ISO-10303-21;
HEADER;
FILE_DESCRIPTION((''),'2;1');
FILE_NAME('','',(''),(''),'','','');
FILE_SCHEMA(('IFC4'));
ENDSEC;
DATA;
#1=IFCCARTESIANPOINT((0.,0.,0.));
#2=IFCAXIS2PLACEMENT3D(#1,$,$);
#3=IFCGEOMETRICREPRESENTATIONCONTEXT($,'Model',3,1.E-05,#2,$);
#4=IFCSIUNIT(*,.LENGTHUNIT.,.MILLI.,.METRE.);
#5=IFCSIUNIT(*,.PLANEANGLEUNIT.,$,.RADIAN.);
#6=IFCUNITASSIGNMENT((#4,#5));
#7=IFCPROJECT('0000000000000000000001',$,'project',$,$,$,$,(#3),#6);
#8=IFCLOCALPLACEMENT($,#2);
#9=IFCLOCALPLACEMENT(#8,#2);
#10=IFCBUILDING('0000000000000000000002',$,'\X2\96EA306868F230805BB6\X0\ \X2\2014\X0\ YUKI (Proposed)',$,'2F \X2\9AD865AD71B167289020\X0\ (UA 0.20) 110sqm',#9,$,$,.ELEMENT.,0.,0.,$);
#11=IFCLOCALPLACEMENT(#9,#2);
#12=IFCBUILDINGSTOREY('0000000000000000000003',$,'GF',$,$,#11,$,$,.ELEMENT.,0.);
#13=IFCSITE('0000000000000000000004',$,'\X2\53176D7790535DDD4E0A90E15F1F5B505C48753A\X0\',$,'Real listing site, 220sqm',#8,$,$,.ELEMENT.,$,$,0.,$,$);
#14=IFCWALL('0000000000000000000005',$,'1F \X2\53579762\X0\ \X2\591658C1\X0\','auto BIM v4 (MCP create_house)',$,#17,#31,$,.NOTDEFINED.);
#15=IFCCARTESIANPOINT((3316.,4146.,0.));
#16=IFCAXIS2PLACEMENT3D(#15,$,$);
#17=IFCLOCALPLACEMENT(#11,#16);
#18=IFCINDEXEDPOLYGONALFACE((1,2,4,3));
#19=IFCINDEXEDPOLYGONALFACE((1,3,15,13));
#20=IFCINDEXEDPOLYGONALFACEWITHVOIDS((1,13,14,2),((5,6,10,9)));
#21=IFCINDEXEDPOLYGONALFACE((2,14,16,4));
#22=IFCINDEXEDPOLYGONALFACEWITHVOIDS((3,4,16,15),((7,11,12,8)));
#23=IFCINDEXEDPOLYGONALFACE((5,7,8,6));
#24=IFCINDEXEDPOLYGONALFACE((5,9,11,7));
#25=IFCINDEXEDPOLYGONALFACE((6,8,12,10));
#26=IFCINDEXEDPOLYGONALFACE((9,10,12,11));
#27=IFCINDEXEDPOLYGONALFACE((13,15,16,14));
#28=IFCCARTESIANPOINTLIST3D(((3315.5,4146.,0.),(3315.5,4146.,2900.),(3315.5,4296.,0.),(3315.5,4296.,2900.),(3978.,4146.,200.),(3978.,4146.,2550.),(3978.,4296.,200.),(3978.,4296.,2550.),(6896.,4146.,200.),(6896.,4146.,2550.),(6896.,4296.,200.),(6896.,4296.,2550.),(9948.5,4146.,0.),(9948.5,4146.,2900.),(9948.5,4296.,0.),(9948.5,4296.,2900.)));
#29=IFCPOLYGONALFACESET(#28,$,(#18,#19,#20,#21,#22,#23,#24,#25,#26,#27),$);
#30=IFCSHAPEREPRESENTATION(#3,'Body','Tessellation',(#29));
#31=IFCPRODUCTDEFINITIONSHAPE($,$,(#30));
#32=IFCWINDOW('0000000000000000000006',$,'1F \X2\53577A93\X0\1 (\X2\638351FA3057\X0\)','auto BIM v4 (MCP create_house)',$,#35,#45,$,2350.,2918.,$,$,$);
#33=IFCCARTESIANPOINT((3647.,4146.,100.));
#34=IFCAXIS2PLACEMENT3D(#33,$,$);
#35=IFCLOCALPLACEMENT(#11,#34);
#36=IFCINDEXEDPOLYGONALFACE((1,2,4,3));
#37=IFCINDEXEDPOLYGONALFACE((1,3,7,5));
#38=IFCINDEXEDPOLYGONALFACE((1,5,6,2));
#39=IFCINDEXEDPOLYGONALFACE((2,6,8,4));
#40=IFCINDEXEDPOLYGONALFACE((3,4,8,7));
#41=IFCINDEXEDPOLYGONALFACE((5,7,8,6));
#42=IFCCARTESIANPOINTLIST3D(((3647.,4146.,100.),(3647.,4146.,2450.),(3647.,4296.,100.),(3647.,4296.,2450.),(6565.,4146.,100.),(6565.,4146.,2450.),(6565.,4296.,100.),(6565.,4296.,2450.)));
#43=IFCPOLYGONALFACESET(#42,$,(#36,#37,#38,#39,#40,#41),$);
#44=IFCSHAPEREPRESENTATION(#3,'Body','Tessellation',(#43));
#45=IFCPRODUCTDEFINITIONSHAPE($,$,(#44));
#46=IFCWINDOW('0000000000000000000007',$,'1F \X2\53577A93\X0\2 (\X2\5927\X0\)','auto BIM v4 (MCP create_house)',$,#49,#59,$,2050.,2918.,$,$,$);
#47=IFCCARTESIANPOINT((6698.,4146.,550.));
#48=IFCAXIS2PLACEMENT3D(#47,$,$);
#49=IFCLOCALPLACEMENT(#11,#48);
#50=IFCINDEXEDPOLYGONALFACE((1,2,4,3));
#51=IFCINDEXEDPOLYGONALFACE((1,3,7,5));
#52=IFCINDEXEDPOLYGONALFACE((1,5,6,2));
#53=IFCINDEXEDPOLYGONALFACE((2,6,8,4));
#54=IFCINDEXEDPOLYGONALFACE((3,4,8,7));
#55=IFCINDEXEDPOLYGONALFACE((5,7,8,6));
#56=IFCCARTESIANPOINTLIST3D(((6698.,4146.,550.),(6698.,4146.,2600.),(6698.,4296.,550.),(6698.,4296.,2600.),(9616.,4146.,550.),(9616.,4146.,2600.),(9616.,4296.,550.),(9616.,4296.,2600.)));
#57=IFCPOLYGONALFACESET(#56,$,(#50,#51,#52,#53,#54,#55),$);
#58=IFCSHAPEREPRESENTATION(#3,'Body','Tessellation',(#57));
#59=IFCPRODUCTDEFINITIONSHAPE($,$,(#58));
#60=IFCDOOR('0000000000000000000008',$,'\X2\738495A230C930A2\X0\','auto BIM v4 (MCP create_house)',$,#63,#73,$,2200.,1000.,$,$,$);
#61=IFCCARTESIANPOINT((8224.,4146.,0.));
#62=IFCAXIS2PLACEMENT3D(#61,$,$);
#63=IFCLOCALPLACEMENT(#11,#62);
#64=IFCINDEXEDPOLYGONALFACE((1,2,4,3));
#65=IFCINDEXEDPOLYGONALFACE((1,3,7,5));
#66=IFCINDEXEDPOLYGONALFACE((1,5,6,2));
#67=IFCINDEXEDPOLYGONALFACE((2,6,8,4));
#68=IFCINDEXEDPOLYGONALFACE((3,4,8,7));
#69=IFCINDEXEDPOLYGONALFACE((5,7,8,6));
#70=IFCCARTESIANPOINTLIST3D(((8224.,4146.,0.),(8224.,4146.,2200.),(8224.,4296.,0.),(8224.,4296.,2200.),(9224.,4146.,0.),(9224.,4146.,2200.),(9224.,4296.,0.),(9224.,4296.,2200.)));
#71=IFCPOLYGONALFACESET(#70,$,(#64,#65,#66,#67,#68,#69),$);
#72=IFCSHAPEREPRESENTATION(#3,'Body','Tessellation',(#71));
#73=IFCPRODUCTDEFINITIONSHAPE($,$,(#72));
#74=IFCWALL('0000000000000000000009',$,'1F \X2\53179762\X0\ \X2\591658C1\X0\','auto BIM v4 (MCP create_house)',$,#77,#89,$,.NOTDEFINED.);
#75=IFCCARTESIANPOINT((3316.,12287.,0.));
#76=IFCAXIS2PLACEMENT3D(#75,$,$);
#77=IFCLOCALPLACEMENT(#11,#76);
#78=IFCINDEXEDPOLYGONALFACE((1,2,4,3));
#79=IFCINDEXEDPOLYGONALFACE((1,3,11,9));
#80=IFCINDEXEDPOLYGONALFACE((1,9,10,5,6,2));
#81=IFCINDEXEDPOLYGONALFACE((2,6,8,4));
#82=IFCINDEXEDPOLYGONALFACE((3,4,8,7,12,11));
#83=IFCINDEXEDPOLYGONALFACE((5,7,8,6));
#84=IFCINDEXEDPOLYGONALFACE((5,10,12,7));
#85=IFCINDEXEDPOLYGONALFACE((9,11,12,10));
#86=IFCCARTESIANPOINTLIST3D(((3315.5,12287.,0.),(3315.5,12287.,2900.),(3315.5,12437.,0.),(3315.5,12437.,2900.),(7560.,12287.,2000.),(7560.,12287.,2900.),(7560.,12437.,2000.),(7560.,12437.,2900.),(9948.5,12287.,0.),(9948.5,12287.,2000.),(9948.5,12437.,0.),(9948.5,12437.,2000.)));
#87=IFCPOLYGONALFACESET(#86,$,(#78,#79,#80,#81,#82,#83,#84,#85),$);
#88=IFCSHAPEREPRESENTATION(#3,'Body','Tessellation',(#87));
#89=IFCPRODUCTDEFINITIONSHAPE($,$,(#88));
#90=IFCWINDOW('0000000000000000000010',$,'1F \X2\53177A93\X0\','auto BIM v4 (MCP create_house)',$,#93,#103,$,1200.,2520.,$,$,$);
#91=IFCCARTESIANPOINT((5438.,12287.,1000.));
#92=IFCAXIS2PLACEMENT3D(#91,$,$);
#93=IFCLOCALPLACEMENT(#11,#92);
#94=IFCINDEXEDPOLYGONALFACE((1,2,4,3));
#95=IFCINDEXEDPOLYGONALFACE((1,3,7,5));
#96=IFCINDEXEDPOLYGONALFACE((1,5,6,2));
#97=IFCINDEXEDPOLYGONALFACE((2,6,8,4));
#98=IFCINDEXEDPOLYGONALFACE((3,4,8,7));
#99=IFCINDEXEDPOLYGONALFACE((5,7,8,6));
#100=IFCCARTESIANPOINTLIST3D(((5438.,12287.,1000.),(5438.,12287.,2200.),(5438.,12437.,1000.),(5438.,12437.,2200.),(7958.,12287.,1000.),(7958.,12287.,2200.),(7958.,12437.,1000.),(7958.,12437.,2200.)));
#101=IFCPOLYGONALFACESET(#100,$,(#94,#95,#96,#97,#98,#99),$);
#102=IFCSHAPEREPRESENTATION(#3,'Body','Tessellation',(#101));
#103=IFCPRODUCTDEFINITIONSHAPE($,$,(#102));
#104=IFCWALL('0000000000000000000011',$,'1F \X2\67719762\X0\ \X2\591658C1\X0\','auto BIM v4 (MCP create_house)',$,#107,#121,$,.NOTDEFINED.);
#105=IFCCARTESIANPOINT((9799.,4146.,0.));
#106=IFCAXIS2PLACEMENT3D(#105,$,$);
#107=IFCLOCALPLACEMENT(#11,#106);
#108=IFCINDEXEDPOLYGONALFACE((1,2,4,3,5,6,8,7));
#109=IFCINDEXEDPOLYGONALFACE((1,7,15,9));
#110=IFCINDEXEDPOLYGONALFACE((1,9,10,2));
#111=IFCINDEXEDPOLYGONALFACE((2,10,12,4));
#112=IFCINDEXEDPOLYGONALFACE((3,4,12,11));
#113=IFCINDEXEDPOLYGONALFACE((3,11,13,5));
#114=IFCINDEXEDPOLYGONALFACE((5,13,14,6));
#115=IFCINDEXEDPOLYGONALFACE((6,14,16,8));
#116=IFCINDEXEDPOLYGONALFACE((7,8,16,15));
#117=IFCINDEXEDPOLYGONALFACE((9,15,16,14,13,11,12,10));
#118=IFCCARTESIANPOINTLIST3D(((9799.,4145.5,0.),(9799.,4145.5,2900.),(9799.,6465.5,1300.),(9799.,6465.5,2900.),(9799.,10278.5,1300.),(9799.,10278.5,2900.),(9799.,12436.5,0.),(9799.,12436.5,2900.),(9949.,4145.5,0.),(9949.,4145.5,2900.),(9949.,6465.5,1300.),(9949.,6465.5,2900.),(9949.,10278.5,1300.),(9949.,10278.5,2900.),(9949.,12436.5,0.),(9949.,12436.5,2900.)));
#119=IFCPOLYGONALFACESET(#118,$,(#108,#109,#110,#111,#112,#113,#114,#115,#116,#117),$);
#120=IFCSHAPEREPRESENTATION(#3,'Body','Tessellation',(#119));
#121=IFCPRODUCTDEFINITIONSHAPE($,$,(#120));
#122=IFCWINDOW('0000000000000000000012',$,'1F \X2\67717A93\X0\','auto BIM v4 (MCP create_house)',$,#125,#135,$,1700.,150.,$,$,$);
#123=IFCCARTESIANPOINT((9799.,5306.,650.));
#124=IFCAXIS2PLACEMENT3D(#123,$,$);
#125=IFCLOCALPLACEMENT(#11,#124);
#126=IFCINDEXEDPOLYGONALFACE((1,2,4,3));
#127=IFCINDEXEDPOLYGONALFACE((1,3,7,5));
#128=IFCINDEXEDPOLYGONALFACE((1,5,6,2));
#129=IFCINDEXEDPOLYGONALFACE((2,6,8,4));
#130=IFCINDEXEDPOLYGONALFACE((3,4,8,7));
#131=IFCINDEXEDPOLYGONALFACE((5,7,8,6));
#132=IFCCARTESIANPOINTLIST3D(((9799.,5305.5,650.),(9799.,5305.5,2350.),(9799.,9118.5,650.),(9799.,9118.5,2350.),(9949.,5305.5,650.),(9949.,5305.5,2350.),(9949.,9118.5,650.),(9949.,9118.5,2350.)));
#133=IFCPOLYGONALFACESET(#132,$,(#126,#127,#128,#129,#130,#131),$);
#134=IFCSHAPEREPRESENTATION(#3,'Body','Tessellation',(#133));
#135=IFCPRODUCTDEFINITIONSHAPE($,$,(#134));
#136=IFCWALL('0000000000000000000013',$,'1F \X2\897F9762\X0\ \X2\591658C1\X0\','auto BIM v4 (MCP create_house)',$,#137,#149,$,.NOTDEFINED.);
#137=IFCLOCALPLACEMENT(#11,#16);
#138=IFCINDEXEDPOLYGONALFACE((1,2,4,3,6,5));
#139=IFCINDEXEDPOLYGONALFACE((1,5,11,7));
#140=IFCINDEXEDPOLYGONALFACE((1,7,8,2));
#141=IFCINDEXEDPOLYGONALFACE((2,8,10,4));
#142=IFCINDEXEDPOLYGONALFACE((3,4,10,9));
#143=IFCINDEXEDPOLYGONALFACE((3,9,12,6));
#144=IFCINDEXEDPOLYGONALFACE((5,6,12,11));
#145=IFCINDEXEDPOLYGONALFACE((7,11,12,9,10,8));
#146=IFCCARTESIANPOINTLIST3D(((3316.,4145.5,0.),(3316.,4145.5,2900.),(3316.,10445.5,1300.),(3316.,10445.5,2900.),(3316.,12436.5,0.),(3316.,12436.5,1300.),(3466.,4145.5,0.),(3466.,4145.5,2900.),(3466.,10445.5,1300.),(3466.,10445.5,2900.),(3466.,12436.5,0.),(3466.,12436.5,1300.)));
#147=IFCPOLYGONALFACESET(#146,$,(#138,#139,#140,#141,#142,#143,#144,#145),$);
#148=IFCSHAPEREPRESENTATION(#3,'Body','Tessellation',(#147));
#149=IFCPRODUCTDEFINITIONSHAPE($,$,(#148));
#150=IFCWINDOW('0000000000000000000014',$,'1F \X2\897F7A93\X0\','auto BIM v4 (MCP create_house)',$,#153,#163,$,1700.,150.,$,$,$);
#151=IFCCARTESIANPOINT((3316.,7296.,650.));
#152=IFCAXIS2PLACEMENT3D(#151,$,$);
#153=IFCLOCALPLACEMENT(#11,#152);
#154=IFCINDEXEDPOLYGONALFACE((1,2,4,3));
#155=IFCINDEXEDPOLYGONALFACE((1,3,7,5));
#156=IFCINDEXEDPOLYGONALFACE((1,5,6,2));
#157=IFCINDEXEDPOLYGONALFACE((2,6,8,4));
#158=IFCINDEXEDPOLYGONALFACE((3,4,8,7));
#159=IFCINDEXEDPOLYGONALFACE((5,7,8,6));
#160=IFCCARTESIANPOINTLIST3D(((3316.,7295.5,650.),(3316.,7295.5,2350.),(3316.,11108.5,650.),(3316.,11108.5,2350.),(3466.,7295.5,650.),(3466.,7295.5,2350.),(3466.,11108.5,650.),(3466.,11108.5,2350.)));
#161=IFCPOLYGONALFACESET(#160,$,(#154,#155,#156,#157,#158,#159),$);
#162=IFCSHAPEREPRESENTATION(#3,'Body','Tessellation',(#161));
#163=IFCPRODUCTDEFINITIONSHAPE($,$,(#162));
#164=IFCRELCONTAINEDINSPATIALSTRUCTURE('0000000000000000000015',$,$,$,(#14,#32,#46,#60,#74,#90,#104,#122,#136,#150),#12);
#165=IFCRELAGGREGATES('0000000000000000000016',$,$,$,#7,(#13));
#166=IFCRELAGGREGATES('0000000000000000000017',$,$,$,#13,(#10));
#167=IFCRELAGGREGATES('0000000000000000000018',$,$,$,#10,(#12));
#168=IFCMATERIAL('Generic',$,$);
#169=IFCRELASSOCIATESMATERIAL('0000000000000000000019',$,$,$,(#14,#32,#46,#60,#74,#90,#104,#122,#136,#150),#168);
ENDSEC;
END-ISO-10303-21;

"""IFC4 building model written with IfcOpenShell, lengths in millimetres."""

from ifc_helpers import new_model, si_unit, frame, frame_2d, origin, place, context, project, spatial, rectangle, extrude, material, element, fill, save


model = new_model("IFC4")

# Units and contexts
model_context = context("Model", 3, precision=1e-05, world=origin())
ifc_project = project(units=[si_unit("LENGTHUNIT", "METRE", prefix="MILLI"), si_unit("PLANEANGLEUNIT", "RADIAN")], contexts=[model_context])

# Site, building, storey
site_placement = place(None, origin())
site = spatial("IfcSite", under=ifc_project, at=site_placement, Name="北海道川上郡弟子屈町", ObjectType="Real listing site, 220sqm", CompositionType="ELEMENT", RefElevation=0.0)
building_placement = place(site_placement, origin())
building = spatial("IfcBuilding", under=site, at=building_placement, Name="雪と棲む家 — YUKI (Proposed)", ObjectType="2F 高断熱木造 (UA 0.20) 110sqm", CompositionType="ELEMENT", ElevationOfRefHeight=0.0, ElevationOfTerrain=0.0)
storey_placement = place(building_placement, origin())
storey = spatial("IfcBuildingStorey", under=building, at=storey_placement, Name="GF", CompositionType="ELEMENT", Elevation=0.0)

# Shared definitions
ifc_material = material(Name="Generic")

# Wall, openings, windows, door
wall_1_placement = place(storey_placement, frame((3316.0, 4146.0, 0.0)))
wall_1 = element("IfcWall", 1, at=wall_1_placement, inside=storey, material=ifc_material, Name="1F 南面 外壁", Description="auto BIM v4 (MCP create_house)", PredefinedType="NOTDEFINED", context=model_context, shape_type="SweptSolid", body=[
    extrude(rectangle(XDim=6633.0, YDim=150.0, at=frame_2d((3316.0, 75.0))), frame((3316.0, 4146.0, 0.0)), (0.0, 0.0, 1.0), 2900.0),
])
opening_1_placement = place(storey_placement, frame((3647.0, 4146.0, 100.0)))
opening_1 = element("IfcOpeningElement", 2, at=opening_1_placement, cuts=wall_1, PredefinedType="NOTDEFINED", context=model_context, shape_type="SweptSolid", body=[
    extrude(rectangle(XDim=2918.0, YDim=150.0, at=frame_2d((1459.0, 75.0))), frame((3647.0, 4146.0, 100.0)), (0.0, 0.0, 1.0), 2350.0),
])
opening_2_placement = place(storey_placement, frame((6698.0, 4146.0, 550.0)))
opening_2 = element("IfcOpeningElement", 3, at=opening_2_placement, cuts=wall_1, PredefinedType="NOTDEFINED", context=model_context, shape_type="SweptSolid", body=[
    extrude(rectangle(XDim=2918.0, YDim=150.0, at=frame_2d((1459.0, 75.0))), frame((6698.0, 4146.0, 550.0)), (0.0, 0.0, 1.0), 2050.0),
])
opening_3_placement = place(storey_placement, frame((8224.0, 4146.0, 0.0)))
opening_3 = element("IfcOpeningElement", 4, at=opening_3_placement, cuts=wall_1, PredefinedType="NOTDEFINED", context=model_context, shape_type="SweptSolid", body=[
    extrude(rectangle(XDim=1000.0, YDim=150.0, at=frame_2d((500.0, 75.0))), frame((8224.0, 4146.0, 0.0)), (0.0, 0.0, 1.0), 2200.0),
])
window_1_placement = place(storey_placement, frame((3647.0, 4146.0, 100.0)))
window_1 = element("IfcWindow", 5, at=window_1_placement, inside=storey, material=ifc_material, Name="1F 南窓1 (掃出し)", Description="auto BIM v4 (MCP create_house)", OverallHeight=2350.0, OverallWidth=2918.0, context=model_context, shape_type="SweptSolid", body=[
    extrude(rectangle(XDim=2918.0, YDim=150.0, at=frame_2d((1459.0, 75.0))), frame((3647.0, 4146.0, 100.0)), (0.0, 0.0, 1.0), 2350.0),
])
fill(opening_1, window_1)
window_2_placement = place(storey_placement, frame((6698.0, 4146.0, 550.0)))
window_2 = element("IfcWindow", 6, at=window_2_placement, inside=storey, material=ifc_material, Name="1F 南窓2 (大)", Description="auto BIM v4 (MCP create_house)", OverallHeight=2050.0, OverallWidth=2918.0, context=model_context, shape_type="SweptSolid", body=[
    extrude(rectangle(XDim=2918.0, YDim=150.0, at=frame_2d((1459.0, 75.0))), frame((6698.0, 4146.0, 550.0)), (0.0, 0.0, 1.0), 2050.0),
])
fill(opening_2, window_2)
door_1_placement = place(storey_placement, frame((8224.0, 4146.0, 0.0)))
door_1 = element("IfcDoor", 7, at=door_1_placement, inside=storey, material=ifc_material, Name="玄関ドア", Description="auto BIM v4 (MCP create_house)", OverallHeight=2200.0, OverallWidth=1000.0, context=model_context, shape_type="SweptSolid", body=[
    extrude(rectangle(XDim=1000.0, YDim=150.0, at=frame_2d((500.0, 75.0))), frame((8224.0, 4146.0, 0.0)), (0.0, 0.0, 1.0), 2200.0),
])
fill(opening_3, door_1)

# Walls, openings, windows
wall_2_placement = place(storey_placement, frame((3316.0, 12287.0, 0.0)))
wall_2 = element("IfcWall", 8, at=wall_2_placement, inside=storey, material=ifc_material, Name="1F 北面 外壁", Description="auto BIM v4 (MCP create_house)", PredefinedType="NOTDEFINED", context=model_context, shape_type="SweptSolid", body=[
    extrude(rectangle(XDim=6633.0, YDim=150.0, at=frame_2d((3316.0, 75.0))), frame((3316.0, 12287.0, 0.0)), (0.0, 0.0, 1.0), 2900.0),
])
opening_4_placement = place(storey_placement, frame((5438.0, 12287.0, 1000.0)))
opening_4 = element("IfcOpeningElement", 9, at=opening_4_placement, cuts=wall_2, PredefinedType="NOTDEFINED", context=model_context, shape_type="SweptSolid", body=[
    extrude(rectangle(XDim=2520.0, YDim=150.0, at=frame_2d((1260.0, 75.0))), frame((5438.0, 12287.0, 1000.0)), (0.0, 0.0, 1.0), 1200.0),
])
window_3_placement = place(storey_placement, frame((5438.0, 12287.0, 1000.0)))
window_3 = element("IfcWindow", 10, at=window_3_placement, inside=storey, material=ifc_material, Name="1F 北窓", Description="auto BIM v4 (MCP create_house)", OverallHeight=1200.0, OverallWidth=2520.0, context=model_context, shape_type="SweptSolid", body=[
    extrude(rectangle(XDim=2520.0, YDim=150.0, at=frame_2d((1260.0, 75.0))), frame((5438.0, 12287.0, 1000.0)), (0.0, 0.0, 1.0), 1200.0),
])
fill(opening_4, window_3)
wall_3_placement = place(storey_placement, frame((9799.0, 4146.0, 0.0)))
wall_3 = element("IfcWall", 11, at=wall_3_placement, inside=storey, material=ifc_material, Name="1F 東面 外壁", Description="auto BIM v4 (MCP create_house)", PredefinedType="NOTDEFINED", context=model_context, shape_type="SweptSolid", body=[
    extrude(rectangle(XDim=150.0, YDim=8291.0, at=frame_2d((75.0, 4145.0))), frame((9799.0, 4146.0, 0.0)), (0.0, 0.0, 1.0), 2900.0),
])
opening_5_placement = place(storey_placement, frame((9799.0, 5306.0, 650.0)))
opening_5 = element("IfcOpeningElement", 12, at=opening_5_placement, cuts=wall_3, PredefinedType="NOTDEFINED", context=model_context, shape_type="SweptSolid", body=[
    extrude(rectangle(XDim=150.0, YDim=3813.0, at=frame_2d((75.0, 1906.0))), frame((9799.0, 5306.0, 650.0)), (0.0, 0.0, 1.0), 1700.0),
])
window_4_placement = place(storey_placement, frame((9799.0, 5306.0, 650.0)))
window_4 = element("IfcWindow", 13, at=window_4_placement, inside=storey, material=ifc_material, Name="1F 東窓", Description="auto BIM v4 (MCP create_house)", OverallHeight=1700.0, OverallWidth=150.0, context=model_context, shape_type="SweptSolid", body=[
    extrude(rectangle(XDim=150.0, YDim=3813.0, at=frame_2d((75.0, 1906.0))), frame((9799.0, 5306.0, 650.0)), (0.0, 0.0, 1.0), 1700.0),
])
fill(opening_5, window_4)
wall_4_placement = place(storey_placement, frame((3316.0, 4146.0, 0.0)))
wall_4 = element("IfcWall", 14, at=wall_4_placement, inside=storey, material=ifc_material, Name="1F 西面 外壁", Description="auto BIM v4 (MCP create_house)", PredefinedType="NOTDEFINED", context=model_context, shape_type="SweptSolid", body=[
    extrude(rectangle(XDim=150.0, YDim=8291.0, at=frame_2d((75.0, 4145.0))), frame((3316.0, 4146.0, 0.0)), (0.0, 0.0, 1.0), 2900.0),
])
opening_6_placement = place(storey_placement, frame((3316.0, 7296.0, 650.0)))
opening_6 = element("IfcOpeningElement", 15, at=opening_6_placement, cuts=wall_4, PredefinedType="NOTDEFINED", context=model_context, shape_type="SweptSolid", body=[
    extrude(rectangle(XDim=150.0, YDim=3813.0, at=frame_2d((75.0, 1906.0))), frame((3316.0, 7296.0, 650.0)), (0.0, 0.0, 1.0), 1700.0),
])
window_5_placement = place(storey_placement, frame((3316.0, 7296.0, 650.0)))
window_5 = element("IfcWindow", 16, at=window_5_placement, inside=storey, material=ifc_material, Name="1F 西窓", Description="auto BIM v4 (MCP create_house)", OverallHeight=1700.0, OverallWidth=150.0, context=model_context, shape_type="SweptSolid", body=[
    extrude(rectangle(XDim=150.0, YDim=3813.0, at=frame_2d((75.0, 1906.0))), frame((3316.0, 7296.0, 650.0)), (0.0, 0.0, 1.0), 1700.0),
])
fill(opening_6, window_5)

save(model, "model.ifc")
